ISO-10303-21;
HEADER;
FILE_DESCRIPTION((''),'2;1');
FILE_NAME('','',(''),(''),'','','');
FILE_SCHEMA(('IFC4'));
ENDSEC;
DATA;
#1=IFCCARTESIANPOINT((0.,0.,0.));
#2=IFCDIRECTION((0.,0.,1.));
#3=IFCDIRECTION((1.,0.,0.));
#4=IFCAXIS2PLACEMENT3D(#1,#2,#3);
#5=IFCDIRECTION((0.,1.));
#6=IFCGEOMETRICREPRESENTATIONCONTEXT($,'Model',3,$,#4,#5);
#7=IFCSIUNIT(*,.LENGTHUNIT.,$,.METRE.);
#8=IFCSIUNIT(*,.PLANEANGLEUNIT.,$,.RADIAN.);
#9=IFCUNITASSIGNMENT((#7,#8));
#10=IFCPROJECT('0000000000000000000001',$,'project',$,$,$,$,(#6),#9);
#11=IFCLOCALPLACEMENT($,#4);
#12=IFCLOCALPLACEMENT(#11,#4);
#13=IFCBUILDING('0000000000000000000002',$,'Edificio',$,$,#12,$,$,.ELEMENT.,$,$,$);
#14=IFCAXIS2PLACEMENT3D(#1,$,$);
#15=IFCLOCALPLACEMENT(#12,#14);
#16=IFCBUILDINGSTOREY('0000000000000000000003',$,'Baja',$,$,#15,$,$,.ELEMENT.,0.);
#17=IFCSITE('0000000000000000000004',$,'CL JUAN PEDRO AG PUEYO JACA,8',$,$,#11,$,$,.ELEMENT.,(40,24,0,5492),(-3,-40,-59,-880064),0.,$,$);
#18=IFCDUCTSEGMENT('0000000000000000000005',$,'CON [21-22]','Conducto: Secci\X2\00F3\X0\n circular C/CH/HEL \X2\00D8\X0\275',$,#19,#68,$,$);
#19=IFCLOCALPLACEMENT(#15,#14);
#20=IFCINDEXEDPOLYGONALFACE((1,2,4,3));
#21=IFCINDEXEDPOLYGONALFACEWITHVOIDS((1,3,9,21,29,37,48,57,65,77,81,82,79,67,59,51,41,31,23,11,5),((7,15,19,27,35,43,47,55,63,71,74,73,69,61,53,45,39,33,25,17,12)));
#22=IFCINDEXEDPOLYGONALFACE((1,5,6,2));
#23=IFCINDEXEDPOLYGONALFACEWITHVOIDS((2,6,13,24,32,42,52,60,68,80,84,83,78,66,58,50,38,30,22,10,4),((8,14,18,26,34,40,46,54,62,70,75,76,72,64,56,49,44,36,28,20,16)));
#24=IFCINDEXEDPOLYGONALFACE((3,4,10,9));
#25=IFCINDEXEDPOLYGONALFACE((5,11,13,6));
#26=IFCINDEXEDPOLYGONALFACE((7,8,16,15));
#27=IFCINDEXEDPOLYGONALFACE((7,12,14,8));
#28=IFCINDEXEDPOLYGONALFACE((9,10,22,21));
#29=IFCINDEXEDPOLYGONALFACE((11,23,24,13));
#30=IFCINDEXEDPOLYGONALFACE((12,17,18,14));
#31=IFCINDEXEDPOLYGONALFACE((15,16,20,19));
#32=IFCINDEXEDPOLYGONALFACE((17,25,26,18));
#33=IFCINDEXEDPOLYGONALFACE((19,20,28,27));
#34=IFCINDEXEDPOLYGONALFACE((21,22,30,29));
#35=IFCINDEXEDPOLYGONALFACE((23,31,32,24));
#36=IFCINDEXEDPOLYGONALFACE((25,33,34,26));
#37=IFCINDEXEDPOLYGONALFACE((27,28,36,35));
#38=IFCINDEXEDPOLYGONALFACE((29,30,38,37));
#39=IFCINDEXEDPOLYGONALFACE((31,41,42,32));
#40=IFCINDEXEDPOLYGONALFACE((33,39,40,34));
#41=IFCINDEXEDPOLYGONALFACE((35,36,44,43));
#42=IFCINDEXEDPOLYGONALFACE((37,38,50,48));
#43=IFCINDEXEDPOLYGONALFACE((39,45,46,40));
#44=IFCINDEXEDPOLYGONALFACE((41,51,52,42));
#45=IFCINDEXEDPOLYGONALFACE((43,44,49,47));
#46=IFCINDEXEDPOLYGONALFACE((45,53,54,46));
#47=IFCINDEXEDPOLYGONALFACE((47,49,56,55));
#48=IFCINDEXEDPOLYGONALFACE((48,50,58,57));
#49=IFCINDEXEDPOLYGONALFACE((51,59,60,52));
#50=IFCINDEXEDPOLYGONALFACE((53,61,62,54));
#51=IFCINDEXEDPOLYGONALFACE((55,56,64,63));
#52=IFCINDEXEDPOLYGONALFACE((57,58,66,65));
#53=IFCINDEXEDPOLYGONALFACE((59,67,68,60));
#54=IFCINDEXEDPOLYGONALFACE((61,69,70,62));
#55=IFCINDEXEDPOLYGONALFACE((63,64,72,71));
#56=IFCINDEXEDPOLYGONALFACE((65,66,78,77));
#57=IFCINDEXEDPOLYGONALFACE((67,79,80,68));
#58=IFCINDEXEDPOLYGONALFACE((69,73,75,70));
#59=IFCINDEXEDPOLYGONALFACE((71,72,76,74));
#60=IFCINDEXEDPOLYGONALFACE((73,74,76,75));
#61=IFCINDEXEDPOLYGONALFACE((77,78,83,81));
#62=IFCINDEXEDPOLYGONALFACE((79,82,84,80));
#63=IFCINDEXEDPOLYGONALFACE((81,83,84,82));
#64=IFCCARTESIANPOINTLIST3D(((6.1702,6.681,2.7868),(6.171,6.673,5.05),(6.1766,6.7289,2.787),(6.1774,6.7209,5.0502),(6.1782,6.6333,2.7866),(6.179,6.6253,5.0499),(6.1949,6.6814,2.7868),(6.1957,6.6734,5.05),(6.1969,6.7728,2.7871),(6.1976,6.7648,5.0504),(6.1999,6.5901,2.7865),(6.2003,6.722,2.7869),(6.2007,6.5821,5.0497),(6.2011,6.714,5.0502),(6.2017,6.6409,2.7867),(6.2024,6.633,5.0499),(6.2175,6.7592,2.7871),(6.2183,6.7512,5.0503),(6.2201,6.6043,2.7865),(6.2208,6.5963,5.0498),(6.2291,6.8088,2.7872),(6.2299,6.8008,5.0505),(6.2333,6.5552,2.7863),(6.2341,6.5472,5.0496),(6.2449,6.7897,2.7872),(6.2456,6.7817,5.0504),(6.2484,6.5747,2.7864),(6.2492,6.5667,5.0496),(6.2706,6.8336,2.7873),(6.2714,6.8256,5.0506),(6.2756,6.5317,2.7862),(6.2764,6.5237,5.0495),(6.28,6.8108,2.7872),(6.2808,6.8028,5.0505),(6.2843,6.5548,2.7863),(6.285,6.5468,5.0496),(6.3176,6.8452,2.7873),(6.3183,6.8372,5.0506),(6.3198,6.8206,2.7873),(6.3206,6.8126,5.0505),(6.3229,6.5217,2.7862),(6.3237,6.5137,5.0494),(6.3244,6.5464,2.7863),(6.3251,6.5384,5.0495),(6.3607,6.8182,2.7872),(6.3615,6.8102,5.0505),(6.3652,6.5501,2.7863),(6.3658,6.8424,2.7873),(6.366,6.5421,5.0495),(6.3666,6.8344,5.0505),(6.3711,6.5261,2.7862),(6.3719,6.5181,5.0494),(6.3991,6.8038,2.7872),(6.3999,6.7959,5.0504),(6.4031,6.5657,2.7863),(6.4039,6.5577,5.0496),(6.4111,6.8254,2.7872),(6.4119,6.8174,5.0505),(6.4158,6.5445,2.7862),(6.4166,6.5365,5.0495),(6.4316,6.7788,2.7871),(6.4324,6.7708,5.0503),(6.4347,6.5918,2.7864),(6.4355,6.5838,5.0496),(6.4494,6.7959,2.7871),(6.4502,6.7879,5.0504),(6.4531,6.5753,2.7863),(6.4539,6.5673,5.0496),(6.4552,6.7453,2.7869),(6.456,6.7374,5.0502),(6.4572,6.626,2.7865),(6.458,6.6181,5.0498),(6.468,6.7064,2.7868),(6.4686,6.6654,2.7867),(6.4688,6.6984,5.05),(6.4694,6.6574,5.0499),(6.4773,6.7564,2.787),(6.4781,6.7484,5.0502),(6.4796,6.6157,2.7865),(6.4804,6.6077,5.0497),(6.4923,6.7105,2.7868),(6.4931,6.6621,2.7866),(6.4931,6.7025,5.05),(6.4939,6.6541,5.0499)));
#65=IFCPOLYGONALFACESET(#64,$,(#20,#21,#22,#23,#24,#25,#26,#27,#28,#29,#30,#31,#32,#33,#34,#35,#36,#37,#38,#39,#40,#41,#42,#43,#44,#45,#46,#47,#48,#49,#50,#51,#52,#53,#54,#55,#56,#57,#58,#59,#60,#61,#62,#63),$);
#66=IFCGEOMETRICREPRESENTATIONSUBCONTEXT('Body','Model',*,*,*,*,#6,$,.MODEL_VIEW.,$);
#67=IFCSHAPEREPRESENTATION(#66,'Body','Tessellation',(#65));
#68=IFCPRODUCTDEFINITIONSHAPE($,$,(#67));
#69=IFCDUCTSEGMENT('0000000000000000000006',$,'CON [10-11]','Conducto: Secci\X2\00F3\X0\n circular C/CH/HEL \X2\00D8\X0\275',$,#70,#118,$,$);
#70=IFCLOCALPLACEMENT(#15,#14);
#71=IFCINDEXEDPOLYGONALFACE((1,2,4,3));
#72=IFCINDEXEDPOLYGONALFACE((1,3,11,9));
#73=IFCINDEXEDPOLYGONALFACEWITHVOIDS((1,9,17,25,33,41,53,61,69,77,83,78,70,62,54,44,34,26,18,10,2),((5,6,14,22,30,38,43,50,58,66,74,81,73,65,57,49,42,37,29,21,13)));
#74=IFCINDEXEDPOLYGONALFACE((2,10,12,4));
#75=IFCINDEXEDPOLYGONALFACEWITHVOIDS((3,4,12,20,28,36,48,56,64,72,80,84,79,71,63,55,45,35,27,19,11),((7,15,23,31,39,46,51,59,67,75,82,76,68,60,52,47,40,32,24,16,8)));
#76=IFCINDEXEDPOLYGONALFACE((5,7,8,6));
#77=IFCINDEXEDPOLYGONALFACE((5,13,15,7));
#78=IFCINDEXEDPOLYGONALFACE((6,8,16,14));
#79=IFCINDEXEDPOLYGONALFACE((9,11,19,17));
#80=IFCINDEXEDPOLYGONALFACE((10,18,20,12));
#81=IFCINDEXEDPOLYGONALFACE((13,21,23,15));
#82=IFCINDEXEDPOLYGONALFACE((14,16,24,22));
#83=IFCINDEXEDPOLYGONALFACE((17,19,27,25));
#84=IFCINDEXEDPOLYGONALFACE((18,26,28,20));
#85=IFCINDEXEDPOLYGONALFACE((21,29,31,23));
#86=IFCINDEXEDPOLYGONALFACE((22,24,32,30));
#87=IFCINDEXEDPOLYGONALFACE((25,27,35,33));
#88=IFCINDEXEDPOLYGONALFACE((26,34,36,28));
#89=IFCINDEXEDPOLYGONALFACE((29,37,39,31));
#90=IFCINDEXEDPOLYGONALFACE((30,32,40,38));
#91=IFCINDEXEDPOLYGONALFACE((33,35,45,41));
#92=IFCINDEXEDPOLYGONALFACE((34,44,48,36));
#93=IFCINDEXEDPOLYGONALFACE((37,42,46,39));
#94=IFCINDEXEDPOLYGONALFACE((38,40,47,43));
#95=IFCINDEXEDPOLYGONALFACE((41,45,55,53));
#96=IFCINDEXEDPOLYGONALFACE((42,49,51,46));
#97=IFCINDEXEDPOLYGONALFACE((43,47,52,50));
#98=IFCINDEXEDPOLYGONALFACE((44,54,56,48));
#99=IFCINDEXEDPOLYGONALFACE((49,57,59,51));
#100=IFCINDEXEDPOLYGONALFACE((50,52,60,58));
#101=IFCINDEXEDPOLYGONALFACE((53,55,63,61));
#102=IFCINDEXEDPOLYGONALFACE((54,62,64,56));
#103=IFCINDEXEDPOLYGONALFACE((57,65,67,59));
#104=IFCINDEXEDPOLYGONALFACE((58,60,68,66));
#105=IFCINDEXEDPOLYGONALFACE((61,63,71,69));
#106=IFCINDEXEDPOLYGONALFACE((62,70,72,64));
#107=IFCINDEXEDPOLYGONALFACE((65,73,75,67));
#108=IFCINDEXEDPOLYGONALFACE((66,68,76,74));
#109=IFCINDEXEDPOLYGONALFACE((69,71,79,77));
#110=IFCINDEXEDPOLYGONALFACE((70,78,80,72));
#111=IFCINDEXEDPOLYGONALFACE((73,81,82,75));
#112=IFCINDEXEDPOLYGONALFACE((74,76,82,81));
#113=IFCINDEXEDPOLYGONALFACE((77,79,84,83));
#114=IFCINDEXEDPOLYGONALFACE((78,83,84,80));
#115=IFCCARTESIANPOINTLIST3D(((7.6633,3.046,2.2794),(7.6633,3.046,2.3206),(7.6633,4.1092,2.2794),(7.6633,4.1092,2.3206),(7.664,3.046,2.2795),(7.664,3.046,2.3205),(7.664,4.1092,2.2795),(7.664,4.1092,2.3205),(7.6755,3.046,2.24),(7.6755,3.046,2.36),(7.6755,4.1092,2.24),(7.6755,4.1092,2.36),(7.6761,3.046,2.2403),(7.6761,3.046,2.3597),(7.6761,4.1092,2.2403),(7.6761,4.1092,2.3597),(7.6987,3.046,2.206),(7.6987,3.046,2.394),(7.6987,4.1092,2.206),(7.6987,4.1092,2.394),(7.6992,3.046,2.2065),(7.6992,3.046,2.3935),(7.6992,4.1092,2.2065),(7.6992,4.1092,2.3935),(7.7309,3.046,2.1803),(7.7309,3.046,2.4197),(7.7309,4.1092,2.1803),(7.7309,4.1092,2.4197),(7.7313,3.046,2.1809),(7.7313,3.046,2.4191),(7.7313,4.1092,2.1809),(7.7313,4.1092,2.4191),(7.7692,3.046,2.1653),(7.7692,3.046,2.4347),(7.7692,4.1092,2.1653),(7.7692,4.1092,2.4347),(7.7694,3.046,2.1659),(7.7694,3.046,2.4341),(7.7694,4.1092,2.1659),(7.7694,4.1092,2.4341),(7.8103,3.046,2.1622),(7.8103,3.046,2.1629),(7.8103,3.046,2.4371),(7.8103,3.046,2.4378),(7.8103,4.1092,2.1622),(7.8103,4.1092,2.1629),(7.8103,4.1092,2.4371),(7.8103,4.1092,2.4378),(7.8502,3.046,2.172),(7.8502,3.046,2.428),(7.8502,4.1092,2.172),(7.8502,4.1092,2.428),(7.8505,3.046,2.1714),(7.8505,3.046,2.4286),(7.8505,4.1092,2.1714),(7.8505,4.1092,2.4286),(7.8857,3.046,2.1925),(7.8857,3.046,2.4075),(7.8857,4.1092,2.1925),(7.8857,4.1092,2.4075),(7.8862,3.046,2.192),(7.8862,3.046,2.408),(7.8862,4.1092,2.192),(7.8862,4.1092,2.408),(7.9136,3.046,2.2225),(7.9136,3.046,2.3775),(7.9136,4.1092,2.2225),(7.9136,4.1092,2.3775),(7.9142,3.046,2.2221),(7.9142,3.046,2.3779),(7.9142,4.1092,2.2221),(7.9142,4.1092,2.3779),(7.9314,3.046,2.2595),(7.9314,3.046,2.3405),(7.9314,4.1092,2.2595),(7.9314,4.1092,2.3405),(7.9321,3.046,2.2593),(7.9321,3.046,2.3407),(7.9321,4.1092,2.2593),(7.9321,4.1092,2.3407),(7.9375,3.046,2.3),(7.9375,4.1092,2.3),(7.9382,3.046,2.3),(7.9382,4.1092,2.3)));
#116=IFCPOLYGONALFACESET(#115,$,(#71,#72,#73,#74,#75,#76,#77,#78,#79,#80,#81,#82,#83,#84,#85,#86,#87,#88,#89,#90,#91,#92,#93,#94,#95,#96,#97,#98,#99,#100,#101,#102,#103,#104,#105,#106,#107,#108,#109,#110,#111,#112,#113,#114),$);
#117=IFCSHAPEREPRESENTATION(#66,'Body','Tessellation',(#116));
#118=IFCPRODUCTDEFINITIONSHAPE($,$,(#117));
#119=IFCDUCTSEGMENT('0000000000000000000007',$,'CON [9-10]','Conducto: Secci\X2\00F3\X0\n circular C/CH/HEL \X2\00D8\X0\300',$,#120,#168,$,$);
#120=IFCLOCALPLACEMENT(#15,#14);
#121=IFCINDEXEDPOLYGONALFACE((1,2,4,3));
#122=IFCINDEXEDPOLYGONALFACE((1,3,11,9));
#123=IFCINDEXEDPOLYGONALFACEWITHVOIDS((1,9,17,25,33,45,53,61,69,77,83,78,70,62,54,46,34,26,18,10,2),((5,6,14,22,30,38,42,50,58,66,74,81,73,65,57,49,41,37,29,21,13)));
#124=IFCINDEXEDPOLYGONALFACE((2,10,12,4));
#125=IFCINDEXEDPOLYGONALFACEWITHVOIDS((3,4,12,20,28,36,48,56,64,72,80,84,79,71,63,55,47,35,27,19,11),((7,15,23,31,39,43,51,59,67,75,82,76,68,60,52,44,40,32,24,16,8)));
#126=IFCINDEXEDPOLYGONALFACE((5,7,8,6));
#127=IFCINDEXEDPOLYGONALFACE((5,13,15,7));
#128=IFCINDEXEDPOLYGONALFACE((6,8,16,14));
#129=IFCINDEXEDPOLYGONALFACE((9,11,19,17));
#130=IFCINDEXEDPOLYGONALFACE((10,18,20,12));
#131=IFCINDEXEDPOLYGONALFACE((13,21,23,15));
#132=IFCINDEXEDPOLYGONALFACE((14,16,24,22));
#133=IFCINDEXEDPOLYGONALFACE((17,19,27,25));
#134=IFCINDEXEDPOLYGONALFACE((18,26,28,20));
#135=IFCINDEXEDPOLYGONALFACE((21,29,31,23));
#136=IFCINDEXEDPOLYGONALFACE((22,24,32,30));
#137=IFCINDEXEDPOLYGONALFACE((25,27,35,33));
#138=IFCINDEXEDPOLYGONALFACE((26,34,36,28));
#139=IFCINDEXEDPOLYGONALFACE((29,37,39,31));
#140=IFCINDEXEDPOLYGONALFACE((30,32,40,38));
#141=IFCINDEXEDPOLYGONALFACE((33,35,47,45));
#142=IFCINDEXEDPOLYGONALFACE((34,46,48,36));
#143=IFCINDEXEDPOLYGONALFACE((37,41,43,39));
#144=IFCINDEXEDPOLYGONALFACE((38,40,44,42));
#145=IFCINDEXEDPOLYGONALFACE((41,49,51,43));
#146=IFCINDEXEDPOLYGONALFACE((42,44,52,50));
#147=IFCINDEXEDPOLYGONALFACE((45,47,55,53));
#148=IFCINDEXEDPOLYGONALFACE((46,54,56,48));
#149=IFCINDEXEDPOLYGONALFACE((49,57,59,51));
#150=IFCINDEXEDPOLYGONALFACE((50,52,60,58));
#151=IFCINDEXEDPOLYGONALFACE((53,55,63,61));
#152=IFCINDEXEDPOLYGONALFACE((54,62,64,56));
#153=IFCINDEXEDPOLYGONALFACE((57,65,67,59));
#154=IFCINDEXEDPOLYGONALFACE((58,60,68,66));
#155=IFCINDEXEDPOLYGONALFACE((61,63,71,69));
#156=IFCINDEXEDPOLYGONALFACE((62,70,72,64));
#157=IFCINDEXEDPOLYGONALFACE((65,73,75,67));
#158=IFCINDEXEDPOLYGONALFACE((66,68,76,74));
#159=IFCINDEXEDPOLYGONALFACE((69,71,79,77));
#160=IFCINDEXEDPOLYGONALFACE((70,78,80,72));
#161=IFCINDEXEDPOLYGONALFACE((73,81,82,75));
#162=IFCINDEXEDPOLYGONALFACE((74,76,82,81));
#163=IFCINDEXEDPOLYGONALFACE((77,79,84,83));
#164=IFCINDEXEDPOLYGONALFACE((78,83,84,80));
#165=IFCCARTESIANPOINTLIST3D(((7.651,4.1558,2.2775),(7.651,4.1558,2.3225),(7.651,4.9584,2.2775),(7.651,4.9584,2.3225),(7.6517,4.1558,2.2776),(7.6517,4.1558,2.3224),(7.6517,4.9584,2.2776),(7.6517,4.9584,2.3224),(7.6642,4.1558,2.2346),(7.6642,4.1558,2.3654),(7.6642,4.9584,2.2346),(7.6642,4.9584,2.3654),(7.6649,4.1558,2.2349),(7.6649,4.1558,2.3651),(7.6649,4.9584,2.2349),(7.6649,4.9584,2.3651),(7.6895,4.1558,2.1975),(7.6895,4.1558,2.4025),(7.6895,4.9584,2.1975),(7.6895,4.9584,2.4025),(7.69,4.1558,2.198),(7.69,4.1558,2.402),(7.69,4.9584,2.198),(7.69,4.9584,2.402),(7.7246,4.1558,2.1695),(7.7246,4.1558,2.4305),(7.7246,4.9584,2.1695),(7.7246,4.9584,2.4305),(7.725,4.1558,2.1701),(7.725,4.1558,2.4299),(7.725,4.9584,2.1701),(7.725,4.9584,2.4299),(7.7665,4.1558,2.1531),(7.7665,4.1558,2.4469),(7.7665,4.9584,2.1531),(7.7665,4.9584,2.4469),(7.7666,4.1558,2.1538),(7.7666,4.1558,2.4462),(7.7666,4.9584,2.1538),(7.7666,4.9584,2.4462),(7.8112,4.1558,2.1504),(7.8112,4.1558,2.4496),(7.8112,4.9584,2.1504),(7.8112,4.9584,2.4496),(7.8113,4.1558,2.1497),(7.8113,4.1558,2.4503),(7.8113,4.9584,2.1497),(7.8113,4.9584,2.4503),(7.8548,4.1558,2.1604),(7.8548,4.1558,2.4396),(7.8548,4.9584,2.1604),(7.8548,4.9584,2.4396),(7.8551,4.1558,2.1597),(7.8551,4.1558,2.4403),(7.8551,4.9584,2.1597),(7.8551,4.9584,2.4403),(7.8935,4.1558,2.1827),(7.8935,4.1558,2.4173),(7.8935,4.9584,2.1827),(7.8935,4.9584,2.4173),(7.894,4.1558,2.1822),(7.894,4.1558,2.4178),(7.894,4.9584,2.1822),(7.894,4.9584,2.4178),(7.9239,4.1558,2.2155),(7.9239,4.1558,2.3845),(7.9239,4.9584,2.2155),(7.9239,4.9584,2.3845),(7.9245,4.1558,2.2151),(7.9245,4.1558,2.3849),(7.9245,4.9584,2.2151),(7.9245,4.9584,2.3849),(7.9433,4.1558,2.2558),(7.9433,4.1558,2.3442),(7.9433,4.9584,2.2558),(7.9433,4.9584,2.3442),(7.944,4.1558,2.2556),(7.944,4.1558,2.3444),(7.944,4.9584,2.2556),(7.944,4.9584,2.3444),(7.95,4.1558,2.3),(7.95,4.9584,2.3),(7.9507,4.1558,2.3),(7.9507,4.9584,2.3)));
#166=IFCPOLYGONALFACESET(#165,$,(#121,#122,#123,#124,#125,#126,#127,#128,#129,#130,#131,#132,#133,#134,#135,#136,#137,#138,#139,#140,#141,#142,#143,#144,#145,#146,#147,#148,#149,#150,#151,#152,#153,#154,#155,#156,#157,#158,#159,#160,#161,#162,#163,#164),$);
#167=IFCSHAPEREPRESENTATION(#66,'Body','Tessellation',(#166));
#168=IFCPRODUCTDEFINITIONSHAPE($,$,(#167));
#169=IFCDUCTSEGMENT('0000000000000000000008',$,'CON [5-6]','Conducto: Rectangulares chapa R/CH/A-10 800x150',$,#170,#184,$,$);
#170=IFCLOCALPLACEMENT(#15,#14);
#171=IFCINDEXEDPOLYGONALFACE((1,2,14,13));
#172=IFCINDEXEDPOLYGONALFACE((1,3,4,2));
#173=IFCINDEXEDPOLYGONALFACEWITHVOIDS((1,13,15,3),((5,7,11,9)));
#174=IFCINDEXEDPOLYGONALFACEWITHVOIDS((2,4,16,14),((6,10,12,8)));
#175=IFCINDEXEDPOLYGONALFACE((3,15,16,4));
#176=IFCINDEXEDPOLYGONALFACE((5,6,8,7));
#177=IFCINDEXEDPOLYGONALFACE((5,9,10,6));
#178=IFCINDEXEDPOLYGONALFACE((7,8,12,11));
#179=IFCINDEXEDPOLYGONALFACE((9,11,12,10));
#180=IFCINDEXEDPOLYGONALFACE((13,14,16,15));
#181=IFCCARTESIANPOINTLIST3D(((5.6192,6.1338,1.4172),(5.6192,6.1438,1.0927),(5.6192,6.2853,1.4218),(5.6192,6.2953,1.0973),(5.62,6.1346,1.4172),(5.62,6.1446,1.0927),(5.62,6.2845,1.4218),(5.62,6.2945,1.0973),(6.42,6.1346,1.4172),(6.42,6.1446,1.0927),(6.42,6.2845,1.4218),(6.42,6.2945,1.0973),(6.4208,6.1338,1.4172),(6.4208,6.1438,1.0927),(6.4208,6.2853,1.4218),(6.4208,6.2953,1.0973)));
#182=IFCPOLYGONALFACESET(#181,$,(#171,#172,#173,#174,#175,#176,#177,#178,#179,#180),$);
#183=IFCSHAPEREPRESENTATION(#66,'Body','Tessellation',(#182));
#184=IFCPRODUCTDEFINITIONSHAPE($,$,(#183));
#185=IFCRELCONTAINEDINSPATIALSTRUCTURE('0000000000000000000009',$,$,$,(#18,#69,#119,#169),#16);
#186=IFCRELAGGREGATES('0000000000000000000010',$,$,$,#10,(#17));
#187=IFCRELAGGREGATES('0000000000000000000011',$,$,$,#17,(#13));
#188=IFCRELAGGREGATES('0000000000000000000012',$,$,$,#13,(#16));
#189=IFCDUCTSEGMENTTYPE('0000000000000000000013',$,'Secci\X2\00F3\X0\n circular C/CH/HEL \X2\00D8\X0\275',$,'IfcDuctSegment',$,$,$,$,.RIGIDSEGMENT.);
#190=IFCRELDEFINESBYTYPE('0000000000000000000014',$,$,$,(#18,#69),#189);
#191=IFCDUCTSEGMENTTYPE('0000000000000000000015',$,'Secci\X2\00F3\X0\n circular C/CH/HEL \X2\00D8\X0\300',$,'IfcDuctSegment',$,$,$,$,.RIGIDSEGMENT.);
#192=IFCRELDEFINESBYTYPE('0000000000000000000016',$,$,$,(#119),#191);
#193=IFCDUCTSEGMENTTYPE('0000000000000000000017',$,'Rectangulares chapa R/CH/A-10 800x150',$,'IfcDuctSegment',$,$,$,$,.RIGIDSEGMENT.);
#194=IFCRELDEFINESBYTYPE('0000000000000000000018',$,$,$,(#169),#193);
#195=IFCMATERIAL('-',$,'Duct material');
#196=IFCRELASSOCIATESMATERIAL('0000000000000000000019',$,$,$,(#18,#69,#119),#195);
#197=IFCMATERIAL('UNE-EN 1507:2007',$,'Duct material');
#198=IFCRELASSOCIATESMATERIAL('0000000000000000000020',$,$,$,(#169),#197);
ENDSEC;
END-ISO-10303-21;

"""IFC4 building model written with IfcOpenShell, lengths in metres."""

from ifc_helpers import new_model, si_unit, direction, frame, origin, origin_with_axes, origin_2d_with_axis, place, context, subcontext, project, spatial, hollow_rectangle, hollow_circle, extrude, material, type_object, element, save


model = new_model("IFC4")

# Units and contexts
model_context = context("Model", 3, world=origin_with_axes(), true_north=direction((0.0, 1.0)))
body_context = subcontext(model_context, "Body", "Model", "MODEL_VIEW")
ifc_project = project(units=[si_unit("LENGTHUNIT", "METRE"), si_unit("PLANEANGLEUNIT", "RADIAN")], contexts=[model_context])

# Site, building, storey
site_placement = place(None, origin_with_axes())
site = spatial("IfcSite", under=ifc_project, at=site_placement, Name="CL JUAN PEDRO AG PUEYO JACA,8", CompositionType="ELEMENT", RefLatitude=(40, 24, 0, 5492), RefLongitude=(-3, -40, -59, -880064), RefElevation=0.0)
building_placement = place(site_placement, origin_with_axes())
building = spatial("IfcBuilding", under=site, at=building_placement, Name="Edificio", CompositionType="ELEMENT")
storey_placement = place(building_placement, origin())
storey = spatial("IfcBuildingStorey", under=building, at=storey_placement, Name="Baja", CompositionType="ELEMENT", Elevation=0.0)

# Duct segments
ifc_material_1 = material(Name="-", Category="Duct material")
duct_segment_type_1 = type_object("IfcDuctSegmentType", Name="Sección circular C/CH/HEL Ø275", ApplicableOccurrence="IfcDuctSegment", PredefinedType="RIGIDSEGMENT")
duct_segment_1_placement = place(storey_placement, origin_with_axes())
element("IfcDuctSegment", 1, at=duct_segment_1_placement, inside=storey, type_object=duct_segment_type_1, material=ifc_material_1, Name="CON [21-22]", Description="Conducto: Sección circular C/CH/HEL Ø275", context=body_context, shape_type="SweptSolid", body=[
    extrude(hollow_circle(Radius=0.1622, WallThickness=0.0247, at=origin_2d_with_axis()), frame((6.3331, 6.6757, 5.05), z_axis=(-0.000346, 0.00353, -0.999994), x_axis=(-0.091225, 0.995824, 0.003547)), (0.0, 0.0, 1.0), 2.2632),
])
duct_segment_2_placement = place(storey_placement, origin_with_axes())
element("IfcDuctSegment", 2, at=duct_segment_2_placement, inside=storey, type_object=duct_segment_type_1, material=ifc_material_1, Name="CON [10-11]", Description="Conducto: Sección circular C/CH/HEL Ø275", context=body_context, shape_type="SweptSolid", body=[
    extrude(hollow_circle(Radius=0.1382, WallThickness=0.0007, at=origin_2d_with_axis()), frame((7.8, 4.1092, 2.3), z_axis=(0.0, -1.0, 0.0), x_axis=(1.0, 0.0, 0.0)), (0.0, 0.0, 1.0), 1.0632),
])
duct_segment_type_2 = type_object("IfcDuctSegmentType", Name="Sección circular C/CH/HEL Ø300", ApplicableOccurrence="IfcDuctSegment", PredefinedType="RIGIDSEGMENT")
duct_segment_3_placement = place(storey_placement, origin_with_axes())
element("IfcDuctSegment", 3, at=duct_segment_3_placement, inside=storey, type_object=duct_segment_type_2, material=ifc_material_1, Name="CON [9-10]", Description="Conducto: Sección circular C/CH/HEL Ø300", context=body_context, shape_type="SweptSolid", body=[
    extrude(hollow_circle(Radius=0.1507, WallThickness=0.0007, at=origin_2d_with_axis()), frame((7.8, 4.9584, 2.3), z_axis=(0.0, -1.0, 0.0), x_axis=(1.0, 0.0, 0.0)), (0.0, 0.0, 1.0), 0.8026),
])
ifc_material_2 = material(Name="UNE-EN 1507:2007", Category="Duct material")
duct_segment_type_3 = type_object("IfcDuctSegmentType", Name="Rectangulares chapa R/CH/A-10 800x150", ApplicableOccurrence="IfcDuctSegment", PredefinedType="RIGIDSEGMENT")
duct_segment_4_placement = place(storey_placement, origin_with_axes())
element("IfcDuctSegment", 4, at=duct_segment_4_placement, inside=storey, type_object=duct_segment_type_3, material=ifc_material_2, Name="CON [5-6]", Description="Conducto: Rectangulares chapa R/CH/A-10 800x150", context=body_context, shape_type="SweptSolid", body=[
    extrude(hollow_rectangle(XDim=0.8016, YDim=0.1516, WallThickness=0.0008, at=origin_2d_with_axis()), frame((6.02, 6.2195, 1.095), z_axis=(0.0, -0.030865, 0.999524), x_axis=(1.0, 0.0, 0.0)), (0.0, 0.0, 1.0), 0.3247),
])

save(model, "model.ifc")
